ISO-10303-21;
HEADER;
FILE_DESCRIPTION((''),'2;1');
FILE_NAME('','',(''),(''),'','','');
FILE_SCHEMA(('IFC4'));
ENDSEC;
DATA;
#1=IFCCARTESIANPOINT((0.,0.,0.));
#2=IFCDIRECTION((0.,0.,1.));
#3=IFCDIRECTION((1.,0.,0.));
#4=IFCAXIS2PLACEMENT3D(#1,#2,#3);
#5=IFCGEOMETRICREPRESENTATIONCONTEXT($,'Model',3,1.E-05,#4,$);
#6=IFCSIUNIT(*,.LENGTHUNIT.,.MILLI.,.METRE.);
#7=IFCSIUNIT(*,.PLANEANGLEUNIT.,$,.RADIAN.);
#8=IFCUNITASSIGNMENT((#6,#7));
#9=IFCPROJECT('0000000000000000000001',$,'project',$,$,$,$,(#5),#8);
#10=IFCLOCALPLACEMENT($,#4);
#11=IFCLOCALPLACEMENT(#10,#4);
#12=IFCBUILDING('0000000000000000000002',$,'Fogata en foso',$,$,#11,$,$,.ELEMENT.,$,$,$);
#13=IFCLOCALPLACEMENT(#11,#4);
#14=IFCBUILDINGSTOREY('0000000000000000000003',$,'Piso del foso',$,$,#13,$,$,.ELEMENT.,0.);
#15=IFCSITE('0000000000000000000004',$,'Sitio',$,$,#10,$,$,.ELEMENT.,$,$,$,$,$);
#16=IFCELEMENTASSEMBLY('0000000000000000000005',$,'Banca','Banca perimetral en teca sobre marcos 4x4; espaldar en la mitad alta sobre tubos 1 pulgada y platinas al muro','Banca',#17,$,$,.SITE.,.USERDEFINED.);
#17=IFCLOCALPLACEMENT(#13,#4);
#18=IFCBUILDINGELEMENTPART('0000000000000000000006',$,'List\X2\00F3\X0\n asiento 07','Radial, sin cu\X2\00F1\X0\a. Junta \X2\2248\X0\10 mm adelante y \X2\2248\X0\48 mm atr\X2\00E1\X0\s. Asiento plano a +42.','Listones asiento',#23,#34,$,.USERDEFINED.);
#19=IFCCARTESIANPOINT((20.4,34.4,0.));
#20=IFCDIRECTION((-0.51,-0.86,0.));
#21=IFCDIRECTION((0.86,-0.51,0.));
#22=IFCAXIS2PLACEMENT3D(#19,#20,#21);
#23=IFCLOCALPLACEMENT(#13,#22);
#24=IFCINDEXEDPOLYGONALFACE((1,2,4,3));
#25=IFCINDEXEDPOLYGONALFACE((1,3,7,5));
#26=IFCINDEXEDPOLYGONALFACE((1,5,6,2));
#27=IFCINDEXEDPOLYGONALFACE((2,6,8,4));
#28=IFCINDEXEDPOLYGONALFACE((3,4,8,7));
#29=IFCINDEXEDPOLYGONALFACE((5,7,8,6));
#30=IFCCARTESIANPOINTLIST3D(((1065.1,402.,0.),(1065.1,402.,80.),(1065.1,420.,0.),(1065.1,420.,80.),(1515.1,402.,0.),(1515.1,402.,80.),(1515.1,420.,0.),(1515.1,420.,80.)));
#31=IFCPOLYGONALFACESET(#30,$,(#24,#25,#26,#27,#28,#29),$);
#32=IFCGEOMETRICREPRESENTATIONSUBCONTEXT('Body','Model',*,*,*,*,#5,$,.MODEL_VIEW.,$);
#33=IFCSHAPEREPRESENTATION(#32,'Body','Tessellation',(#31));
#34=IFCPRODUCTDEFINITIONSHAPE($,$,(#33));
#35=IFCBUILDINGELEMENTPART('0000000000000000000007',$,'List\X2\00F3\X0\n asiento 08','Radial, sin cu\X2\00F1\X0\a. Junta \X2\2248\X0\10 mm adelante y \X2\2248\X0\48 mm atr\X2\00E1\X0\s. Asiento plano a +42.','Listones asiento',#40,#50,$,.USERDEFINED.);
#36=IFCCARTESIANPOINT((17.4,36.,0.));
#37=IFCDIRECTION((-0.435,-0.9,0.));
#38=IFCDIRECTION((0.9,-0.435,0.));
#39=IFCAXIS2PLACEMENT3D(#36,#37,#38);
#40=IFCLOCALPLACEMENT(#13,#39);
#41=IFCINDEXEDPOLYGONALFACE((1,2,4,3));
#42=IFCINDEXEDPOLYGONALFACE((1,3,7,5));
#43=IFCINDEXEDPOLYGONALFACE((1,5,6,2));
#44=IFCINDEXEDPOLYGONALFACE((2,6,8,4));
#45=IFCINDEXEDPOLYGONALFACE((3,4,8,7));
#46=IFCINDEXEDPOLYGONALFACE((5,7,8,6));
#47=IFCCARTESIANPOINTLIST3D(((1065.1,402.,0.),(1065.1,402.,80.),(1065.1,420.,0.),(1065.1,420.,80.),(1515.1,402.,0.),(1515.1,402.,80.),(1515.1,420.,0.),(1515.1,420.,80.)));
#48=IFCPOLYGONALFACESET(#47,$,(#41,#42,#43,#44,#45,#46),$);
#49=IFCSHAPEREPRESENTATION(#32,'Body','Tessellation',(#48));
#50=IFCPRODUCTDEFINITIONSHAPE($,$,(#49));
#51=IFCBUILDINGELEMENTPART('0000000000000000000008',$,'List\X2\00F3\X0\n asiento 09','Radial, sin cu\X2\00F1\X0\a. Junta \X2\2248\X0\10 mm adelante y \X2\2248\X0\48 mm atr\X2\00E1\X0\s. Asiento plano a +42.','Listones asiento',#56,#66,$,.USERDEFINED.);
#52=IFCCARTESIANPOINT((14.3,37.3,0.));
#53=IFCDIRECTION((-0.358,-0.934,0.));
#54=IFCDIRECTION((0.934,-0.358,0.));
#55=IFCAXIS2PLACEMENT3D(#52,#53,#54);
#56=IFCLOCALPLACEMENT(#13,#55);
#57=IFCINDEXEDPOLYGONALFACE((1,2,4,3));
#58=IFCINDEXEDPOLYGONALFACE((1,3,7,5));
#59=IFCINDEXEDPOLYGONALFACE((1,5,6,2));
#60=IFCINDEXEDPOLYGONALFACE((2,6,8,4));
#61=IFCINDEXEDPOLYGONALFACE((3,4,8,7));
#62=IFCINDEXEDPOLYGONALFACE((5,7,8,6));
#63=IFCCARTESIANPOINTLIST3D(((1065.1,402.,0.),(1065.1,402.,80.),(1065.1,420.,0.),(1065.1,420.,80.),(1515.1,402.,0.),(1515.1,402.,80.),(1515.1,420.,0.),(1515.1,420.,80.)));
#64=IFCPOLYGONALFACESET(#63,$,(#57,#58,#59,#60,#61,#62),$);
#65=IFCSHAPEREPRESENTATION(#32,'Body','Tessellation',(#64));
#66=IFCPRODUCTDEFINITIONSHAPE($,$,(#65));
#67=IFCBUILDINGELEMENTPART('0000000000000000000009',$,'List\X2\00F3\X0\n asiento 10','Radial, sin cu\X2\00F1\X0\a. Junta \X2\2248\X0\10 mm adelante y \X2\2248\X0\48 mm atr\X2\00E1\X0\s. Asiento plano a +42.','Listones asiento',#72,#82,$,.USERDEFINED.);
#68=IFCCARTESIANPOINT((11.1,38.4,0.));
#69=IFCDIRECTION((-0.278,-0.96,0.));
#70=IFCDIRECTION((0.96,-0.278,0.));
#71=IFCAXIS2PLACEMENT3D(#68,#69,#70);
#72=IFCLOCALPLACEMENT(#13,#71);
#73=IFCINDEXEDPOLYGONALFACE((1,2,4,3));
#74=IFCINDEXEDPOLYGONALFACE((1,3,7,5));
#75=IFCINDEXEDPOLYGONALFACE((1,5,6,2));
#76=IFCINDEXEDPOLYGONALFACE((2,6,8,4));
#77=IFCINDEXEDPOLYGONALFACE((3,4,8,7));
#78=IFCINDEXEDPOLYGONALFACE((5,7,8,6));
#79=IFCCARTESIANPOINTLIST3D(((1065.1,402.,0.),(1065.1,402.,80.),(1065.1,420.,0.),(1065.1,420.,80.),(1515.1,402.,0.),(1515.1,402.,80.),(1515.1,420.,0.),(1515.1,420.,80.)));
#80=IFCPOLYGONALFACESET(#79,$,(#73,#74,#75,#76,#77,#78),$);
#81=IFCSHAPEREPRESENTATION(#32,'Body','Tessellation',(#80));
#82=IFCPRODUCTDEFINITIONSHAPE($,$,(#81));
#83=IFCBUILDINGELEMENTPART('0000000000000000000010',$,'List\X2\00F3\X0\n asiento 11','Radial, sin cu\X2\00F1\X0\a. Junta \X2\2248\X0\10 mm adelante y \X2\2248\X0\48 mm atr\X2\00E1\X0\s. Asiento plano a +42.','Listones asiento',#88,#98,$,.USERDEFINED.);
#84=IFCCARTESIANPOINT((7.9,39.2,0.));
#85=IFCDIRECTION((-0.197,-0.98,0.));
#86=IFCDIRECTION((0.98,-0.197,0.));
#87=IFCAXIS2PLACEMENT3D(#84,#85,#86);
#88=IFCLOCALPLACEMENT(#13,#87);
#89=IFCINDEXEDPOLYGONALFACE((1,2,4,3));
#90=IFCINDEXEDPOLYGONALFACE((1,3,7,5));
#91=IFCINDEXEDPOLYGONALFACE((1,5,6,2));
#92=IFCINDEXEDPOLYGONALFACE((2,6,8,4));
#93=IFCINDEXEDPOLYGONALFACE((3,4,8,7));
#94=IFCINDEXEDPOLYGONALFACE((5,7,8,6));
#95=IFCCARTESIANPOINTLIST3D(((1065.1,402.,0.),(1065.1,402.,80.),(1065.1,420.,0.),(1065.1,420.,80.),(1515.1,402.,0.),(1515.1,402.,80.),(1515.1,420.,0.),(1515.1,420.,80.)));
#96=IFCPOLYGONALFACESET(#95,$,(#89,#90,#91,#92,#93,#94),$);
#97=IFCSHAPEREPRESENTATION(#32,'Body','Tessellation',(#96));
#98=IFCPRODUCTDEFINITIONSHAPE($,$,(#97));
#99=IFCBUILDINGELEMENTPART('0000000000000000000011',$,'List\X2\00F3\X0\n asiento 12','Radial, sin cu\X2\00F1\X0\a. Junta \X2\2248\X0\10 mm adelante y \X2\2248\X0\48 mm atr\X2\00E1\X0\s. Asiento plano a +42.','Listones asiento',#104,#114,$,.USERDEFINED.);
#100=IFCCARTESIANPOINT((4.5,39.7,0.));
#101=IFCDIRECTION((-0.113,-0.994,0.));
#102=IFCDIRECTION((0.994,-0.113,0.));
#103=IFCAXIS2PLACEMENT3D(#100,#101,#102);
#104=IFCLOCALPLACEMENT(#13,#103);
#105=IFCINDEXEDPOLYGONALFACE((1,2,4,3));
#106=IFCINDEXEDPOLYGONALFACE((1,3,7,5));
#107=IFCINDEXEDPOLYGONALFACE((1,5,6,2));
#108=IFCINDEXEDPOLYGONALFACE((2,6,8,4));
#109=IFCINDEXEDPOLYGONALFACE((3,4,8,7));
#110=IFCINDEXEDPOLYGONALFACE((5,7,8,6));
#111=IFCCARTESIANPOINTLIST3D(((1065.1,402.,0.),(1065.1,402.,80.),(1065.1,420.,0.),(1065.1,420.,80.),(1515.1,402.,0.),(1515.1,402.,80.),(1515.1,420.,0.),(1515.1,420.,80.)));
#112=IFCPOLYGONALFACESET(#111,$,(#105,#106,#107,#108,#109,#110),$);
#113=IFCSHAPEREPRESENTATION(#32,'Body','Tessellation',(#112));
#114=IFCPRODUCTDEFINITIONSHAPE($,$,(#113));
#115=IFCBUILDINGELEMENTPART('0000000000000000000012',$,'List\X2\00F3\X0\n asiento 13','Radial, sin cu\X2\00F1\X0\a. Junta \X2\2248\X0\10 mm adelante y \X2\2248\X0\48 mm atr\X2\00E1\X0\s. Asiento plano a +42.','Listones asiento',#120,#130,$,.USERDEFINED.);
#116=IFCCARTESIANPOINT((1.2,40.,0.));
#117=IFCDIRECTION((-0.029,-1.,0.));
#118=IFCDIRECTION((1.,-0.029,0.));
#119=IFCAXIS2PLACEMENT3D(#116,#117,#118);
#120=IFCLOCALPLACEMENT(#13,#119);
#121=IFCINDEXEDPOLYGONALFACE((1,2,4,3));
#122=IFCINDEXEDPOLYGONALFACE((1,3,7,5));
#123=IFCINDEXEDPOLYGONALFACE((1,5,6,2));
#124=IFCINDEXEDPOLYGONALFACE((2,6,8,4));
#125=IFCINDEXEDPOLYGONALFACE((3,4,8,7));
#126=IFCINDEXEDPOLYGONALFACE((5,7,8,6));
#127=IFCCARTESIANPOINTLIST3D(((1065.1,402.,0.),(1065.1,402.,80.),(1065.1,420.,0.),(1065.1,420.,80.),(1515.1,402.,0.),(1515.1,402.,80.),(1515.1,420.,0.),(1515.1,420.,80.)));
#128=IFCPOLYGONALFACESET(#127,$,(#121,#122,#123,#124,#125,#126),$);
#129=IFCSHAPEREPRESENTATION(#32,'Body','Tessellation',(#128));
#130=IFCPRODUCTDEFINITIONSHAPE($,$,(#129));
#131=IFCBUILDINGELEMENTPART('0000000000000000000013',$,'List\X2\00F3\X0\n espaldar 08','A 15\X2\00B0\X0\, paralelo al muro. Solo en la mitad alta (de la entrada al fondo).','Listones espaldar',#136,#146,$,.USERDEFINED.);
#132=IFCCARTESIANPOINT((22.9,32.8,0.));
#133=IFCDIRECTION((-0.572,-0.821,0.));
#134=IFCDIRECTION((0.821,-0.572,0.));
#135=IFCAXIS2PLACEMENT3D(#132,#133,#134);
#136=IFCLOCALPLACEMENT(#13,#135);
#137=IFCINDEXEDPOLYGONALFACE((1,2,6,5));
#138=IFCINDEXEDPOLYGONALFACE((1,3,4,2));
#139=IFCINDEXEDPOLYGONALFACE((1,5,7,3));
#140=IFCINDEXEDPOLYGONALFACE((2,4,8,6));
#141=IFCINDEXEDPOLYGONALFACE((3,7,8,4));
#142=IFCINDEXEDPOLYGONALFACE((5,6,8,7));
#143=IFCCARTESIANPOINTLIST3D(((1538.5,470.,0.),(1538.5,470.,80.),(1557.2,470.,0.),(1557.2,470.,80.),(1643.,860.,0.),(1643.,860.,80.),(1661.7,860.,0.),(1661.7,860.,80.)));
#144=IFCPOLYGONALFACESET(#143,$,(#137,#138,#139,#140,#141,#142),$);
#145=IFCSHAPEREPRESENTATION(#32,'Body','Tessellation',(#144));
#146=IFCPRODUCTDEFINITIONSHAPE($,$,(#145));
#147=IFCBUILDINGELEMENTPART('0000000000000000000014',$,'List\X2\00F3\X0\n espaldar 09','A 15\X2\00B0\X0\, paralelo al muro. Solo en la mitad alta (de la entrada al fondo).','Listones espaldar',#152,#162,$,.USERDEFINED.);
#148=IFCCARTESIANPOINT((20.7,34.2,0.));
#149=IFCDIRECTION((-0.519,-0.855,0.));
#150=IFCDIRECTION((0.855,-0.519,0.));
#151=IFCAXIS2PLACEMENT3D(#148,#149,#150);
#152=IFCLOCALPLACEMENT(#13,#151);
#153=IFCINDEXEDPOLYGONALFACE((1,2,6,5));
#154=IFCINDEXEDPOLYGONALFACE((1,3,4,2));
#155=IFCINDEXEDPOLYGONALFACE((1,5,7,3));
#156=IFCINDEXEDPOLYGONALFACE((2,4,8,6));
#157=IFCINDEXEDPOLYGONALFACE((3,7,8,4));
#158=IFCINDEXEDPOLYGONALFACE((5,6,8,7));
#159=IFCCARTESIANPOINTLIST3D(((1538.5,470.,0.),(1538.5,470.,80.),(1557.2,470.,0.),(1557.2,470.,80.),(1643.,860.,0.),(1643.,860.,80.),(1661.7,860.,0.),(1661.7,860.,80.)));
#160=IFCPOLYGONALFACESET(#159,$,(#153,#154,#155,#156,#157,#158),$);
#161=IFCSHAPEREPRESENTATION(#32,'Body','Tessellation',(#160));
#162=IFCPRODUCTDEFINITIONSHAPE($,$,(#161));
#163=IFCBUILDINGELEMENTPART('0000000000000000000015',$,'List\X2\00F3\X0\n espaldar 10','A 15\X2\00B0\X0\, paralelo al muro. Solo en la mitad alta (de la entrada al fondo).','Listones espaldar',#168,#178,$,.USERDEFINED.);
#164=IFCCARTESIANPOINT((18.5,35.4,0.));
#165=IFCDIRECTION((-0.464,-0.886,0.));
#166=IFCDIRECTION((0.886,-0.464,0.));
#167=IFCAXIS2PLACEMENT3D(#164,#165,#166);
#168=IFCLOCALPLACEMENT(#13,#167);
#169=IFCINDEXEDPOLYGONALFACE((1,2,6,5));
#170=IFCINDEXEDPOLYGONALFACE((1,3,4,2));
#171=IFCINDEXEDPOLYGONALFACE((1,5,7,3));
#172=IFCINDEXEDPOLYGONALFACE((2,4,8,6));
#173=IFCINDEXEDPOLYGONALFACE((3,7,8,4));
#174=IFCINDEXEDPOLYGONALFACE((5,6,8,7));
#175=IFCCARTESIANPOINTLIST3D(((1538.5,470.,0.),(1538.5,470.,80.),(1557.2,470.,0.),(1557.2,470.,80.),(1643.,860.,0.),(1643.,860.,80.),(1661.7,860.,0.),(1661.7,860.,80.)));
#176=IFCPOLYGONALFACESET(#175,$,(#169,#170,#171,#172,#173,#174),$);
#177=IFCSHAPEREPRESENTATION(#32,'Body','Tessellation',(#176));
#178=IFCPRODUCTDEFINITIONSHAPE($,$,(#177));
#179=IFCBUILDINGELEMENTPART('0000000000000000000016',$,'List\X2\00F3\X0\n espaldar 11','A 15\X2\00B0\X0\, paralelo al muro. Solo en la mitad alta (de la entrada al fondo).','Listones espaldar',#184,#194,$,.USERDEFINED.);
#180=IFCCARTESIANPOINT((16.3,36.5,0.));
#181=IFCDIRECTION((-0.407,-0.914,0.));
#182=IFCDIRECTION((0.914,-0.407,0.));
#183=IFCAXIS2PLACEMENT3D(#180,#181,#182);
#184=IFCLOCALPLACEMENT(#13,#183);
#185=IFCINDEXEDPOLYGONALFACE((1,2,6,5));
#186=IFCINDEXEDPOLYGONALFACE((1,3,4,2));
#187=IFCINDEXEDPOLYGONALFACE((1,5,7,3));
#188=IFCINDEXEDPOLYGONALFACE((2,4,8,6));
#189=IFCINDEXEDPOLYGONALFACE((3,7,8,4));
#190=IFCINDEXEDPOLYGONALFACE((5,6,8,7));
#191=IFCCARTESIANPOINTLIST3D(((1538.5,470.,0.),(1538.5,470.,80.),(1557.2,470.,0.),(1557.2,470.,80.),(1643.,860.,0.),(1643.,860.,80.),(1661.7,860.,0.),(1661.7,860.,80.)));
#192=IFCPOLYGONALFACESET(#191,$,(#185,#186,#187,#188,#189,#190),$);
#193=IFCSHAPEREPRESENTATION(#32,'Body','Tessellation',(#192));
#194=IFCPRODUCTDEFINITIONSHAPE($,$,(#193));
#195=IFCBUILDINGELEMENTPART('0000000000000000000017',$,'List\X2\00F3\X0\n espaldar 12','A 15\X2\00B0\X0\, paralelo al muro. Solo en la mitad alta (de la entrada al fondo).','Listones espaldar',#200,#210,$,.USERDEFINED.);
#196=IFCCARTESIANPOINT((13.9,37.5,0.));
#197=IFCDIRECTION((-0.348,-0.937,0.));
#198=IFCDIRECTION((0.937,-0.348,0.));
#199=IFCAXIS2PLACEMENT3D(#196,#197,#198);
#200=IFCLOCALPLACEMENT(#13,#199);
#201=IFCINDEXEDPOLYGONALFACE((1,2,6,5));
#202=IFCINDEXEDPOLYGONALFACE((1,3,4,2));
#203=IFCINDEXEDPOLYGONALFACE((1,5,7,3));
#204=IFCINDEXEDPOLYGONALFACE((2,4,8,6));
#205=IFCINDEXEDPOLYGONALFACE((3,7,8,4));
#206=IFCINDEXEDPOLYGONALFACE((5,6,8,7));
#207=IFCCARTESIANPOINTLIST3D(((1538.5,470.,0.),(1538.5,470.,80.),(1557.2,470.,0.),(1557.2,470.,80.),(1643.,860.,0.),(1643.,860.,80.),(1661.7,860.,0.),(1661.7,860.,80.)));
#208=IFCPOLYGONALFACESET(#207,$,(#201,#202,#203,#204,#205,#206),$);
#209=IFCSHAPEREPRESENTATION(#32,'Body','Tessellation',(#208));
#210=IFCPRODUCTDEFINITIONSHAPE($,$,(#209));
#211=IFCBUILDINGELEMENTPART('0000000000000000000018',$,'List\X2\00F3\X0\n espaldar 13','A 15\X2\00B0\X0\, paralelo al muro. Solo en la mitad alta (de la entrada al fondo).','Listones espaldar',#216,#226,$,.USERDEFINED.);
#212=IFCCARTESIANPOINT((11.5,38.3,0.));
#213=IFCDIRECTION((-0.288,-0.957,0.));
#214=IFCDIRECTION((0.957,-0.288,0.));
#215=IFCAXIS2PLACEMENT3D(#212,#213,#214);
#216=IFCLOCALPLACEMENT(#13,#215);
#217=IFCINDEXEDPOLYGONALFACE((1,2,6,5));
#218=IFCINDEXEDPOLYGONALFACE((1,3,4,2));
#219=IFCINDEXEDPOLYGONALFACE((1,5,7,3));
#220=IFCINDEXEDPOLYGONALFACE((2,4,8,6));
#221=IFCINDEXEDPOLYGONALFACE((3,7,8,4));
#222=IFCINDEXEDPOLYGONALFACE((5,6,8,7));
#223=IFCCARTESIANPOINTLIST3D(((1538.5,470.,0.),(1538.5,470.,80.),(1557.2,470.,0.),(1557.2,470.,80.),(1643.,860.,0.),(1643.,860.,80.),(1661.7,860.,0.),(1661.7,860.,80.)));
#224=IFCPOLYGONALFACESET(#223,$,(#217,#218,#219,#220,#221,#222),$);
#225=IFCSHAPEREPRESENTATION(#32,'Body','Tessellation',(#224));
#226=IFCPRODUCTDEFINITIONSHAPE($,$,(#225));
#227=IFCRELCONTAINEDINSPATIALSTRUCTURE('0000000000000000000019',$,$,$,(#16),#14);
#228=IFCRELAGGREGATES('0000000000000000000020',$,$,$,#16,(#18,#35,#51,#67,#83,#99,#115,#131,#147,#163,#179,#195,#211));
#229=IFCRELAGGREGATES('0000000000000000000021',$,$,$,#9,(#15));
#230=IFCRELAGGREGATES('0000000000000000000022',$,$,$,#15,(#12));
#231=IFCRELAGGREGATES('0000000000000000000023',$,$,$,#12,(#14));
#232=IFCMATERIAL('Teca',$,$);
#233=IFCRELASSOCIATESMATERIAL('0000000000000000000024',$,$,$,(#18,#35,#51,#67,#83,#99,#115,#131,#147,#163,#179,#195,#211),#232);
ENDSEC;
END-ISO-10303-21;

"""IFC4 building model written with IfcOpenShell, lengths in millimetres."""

from ifc_helpers import new_model, si_unit, frame, origin_with_axes, place, context, subcontext, project, spatial, polyline, outline, extrude, material, element, aggregate, save


model = new_model("IFC4")

# Units and contexts
model_context = context("Model", 3, precision=1e-05, world=origin_with_axes())
body_context = subcontext(model_context, "Body", "Model", "MODEL_VIEW")
ifc_project = project(units=[si_unit("LENGTHUNIT", "METRE", prefix="MILLI"), si_unit("PLANEANGLEUNIT", "RADIAN")], contexts=[model_context])

# Site, building, storey
site_placement = place(None, origin_with_axes())
site = spatial("IfcSite", under=ifc_project, at=site_placement, Name="Sitio", CompositionType="ELEMENT")
building_placement = place(site_placement, origin_with_axes())
building = spatial("IfcBuilding", under=site, at=building_placement, Name="Fogata en foso", CompositionType="ELEMENT")
storey_placement = place(building_placement, origin_with_axes())
storey = spatial("IfcBuildingStorey", under=building, at=storey_placement, Name="Piso del foso", CompositionType="ELEMENT", Elevation=0.0)

# Element assembly, building element parts
assembly_1_placement = place(storey_placement, origin_with_axes())
assembly_1 = element("IfcElementAssembly", 1, at=assembly_1_placement, inside=storey, Name="Banca", Description="Banca perimetral en teca sobre marcos 4x4; espaldar en la mitad alta sobre tubos 1 pulgada y platinas al muro", ObjectType="Banca", AssemblyPlace="SITE", PredefinedType="USERDEFINED")
ifc_material = material(Name="Teca")
building_element_part_1_placement = place(storey_placement, frame((20.4, 34.4, 0.0), z_axis=(-0.51, -0.86, 0.0), x_axis=(0.86, -0.51, 0.0)))
building_element_part_1 = element("IfcBuildingElementPart", 2, at=building_element_part_1_placement, material=ifc_material, Name="Listón asiento 07", Description="Radial, sin cuña. Junta ≈10 mm adelante y ≈48 mm atrás. Asiento plano a +42.", ObjectType="Listones asiento", PredefinedType="USERDEFINED", context=body_context, shape_type="SweptSolid", body=[
    extrude(outline(polyline([(1065.1, 402.0), (1515.1, 402.0), (1515.1, 420.0), (1065.1, 420.0), (1065.1, 402.0)])), origin_with_axes(), (0.0, 0.0, 1.0), 80.0),
])
building_element_part_2_placement = place(storey_placement, frame((17.4, 36.0, 0.0), z_axis=(-0.435, -0.9, 0.0), x_axis=(0.9, -0.435, 0.0)))
building_element_part_2 = element("IfcBuildingElementPart", 3, at=building_element_part_2_placement, material=ifc_material, Name="Listón asiento 08", Description="Radial, sin cuña. Junta ≈10 mm adelante y ≈48 mm atrás. Asiento plano a +42.", ObjectType="Listones asiento", PredefinedType="USERDEFINED", context=body_context, shape_type="SweptSolid", body=[
    extrude(outline(polyline([(1065.1, 402.0), (1515.1, 402.0), (1515.1, 420.0), (1065.1, 420.0), (1065.1, 402.0)])), origin_with_axes(), (0.0, 0.0, 1.0), 80.0),
])
building_element_part_3_placement = place(storey_placement, frame((14.3, 37.3, 0.0), z_axis=(-0.358, -0.934, 0.0), x_axis=(0.934, -0.358, 0.0)))
building_element_part_3 = element("IfcBuildingElementPart", 4, at=building_element_part_3_placement, material=ifc_material, Name="Listón asiento 09", Description="Radial, sin cuña. Junta ≈10 mm adelante y ≈48 mm atrás. Asiento plano a +42.", ObjectType="Listones asiento", PredefinedType="USERDEFINED", context=body_context, shape_type="SweptSolid", body=[
    extrude(outline(polyline([(1065.1, 402.0), (1515.1, 402.0), (1515.1, 420.0), (1065.1, 420.0), (1065.1, 402.0)])), origin_with_axes(), (0.0, 0.0, 1.0), 80.0),
])
building_element_part_4_placement = place(storey_placement, frame((11.1, 38.4, 0.0), z_axis=(-0.278, -0.96, 0.0), x_axis=(0.96, -0.278, 0.0)))
building_element_part_4 = element("IfcBuildingElementPart", 5, at=building_element_part_4_placement, material=ifc_material, Name="Listón asiento 10", Description="Radial, sin cuña. Junta ≈10 mm adelante y ≈48 mm atrás. Asiento plano a +42.", ObjectType="Listones asiento", PredefinedType="USERDEFINED", context=body_context, shape_type="SweptSolid", body=[
    extrude(outline(polyline([(1065.1, 402.0), (1515.1, 402.0), (1515.1, 420.0), (1065.1, 420.0), (1065.1, 402.0)])), origin_with_axes(), (0.0, 0.0, 1.0), 80.0),
])
building_element_part_5_placement = place(storey_placement, frame((7.9, 39.2, 0.0), z_axis=(-0.197, -0.98, 0.0), x_axis=(0.98, -0.197, 0.0)))
building_element_part_5 = element("IfcBuildingElementPart", 6, at=building_element_part_5_placement, material=ifc_material, Name="Listón asiento 11", Description="Radial, sin cuña. Junta ≈10 mm adelante y ≈48 mm atrás. Asiento plano a +42.", ObjectType="Listones asiento", PredefinedType="USERDEFINED", context=body_context, shape_type="SweptSolid", body=[
    extrude(outline(polyline([(1065.1, 402.0), (1515.1, 402.0), (1515.1, 420.0), (1065.1, 420.0), (1065.1, 402.0)])), origin_with_axes(), (0.0, 0.0, 1.0), 80.0),
])
building_element_part_6_placement = place(storey_placement, frame((4.5, 39.7, 0.0), z_axis=(-0.113, -0.994, 0.0), x_axis=(0.994, -0.113, 0.0)))
building_element_part_6 = element("IfcBuildingElementPart", 7, at=building_element_part_6_placement, material=ifc_material, Name="Listón asiento 12", Description="Radial, sin cuña. Junta ≈10 mm adelante y ≈48 mm atrás. Asiento plano a +42.", ObjectType="Listones asiento", PredefinedType="USERDEFINED", context=body_context, shape_type="SweptSolid", body=[
    extrude(outline(polyline([(1065.1, 402.0), (1515.1, 402.0), (1515.1, 420.0), (1065.1, 420.0), (1065.1, 402.0)])), origin_with_axes(), (0.0, 0.0, 1.0), 80.0),
])
building_element_part_7_placement = place(storey_placement, frame((1.2, 40.0, 0.0), z_axis=(-0.029, -1.0, 0.0), x_axis=(1.0, -0.029, 0.0)))
building_element_part_7 = element("IfcBuildingElementPart", 8, at=building_element_part_7_placement, material=ifc_material, Name="Listón asiento 13", Description="Radial, sin cuña. Junta ≈10 mm adelante y ≈48 mm atrás. Asiento plano a +42.", ObjectType="Listones asiento", PredefinedType="USERDEFINED", context=body_context, shape_type="SweptSolid", body=[
    extrude(outline(polyline([(1065.1, 402.0), (1515.1, 402.0), (1515.1, 420.0), (1065.1, 420.0), (1065.1, 402.0)])), origin_with_axes(), (0.0, 0.0, 1.0), 80.0),
])
building_element_part_8_placement = place(storey_placement, frame((22.9, 32.8, 0.0), z_axis=(-0.572, -0.821, 0.0), x_axis=(0.821, -0.572, 0.0)))
building_element_part_8 = element("IfcBuildingElementPart", 9, at=building_element_part_8_placement, material=ifc_material, Name="Listón espaldar 08", Description="A 15°, paralelo al muro. Solo en la mitad alta (de la entrada al fondo).", ObjectType="Listones espaldar", PredefinedType="USERDEFINED", context=body_context, shape_type="SweptSolid", body=[
    extrude(outline(polyline([(1538.5, 470.0), (1557.2, 470.0), (1661.7, 860.0), (1643.0, 860.0), (1538.5, 470.0)])), origin_with_axes(), (0.0, 0.0, 1.0), 80.0),
])
building_element_part_9_placement = place(storey_placement, frame((20.7, 34.2, 0.0), z_axis=(-0.519, -0.855, 0.0), x_axis=(0.855, -0.519, 0.0)))
building_element_part_9 = element("IfcBuildingElementPart", 10, at=building_element_part_9_placement, material=ifc_material, Name="Listón espaldar 09", Description="A 15°, paralelo al muro. Solo en la mitad alta (de la entrada al fondo).", ObjectType="Listones espaldar", PredefinedType="USERDEFINED", context=body_context, shape_type="SweptSolid", body=[
    extrude(outline(polyline([(1538.5, 470.0), (1557.2, 470.0), (1661.7, 860.0), (1643.0, 860.0), (1538.5, 470.0)])), origin_with_axes(), (0.0, 0.0, 1.0), 80.0),
])
building_element_part_10_placement = place(storey_placement, frame((18.5, 35.4, 0.0), z_axis=(-0.464, -0.886, 0.0), x_axis=(0.886, -0.464, 0.0)))
building_element_part_10 = element("IfcBuildingElementPart", 11, at=building_element_part_10_placement, material=ifc_material, Name="Listón espaldar 10", Description="A 15°, paralelo al muro. Solo en la mitad alta (de la entrada al fondo).", ObjectType="Listones espaldar", PredefinedType="USERDEFINED", context=body_context, shape_type="SweptSolid", body=[
    extrude(outline(polyline([(1538.5, 470.0), (1557.2, 470.0), (1661.7, 860.0), (1643.0, 860.0), (1538.5, 470.0)])), origin_with_axes(), (0.0, 0.0, 1.0), 80.0),
])
building_element_part_11_placement = place(storey_placement, frame((16.3, 36.5, 0.0), z_axis=(-0.407, -0.914, 0.0), x_axis=(0.914, -0.407, 0.0)))
building_element_part_11 = element("IfcBuildingElementPart", 12, at=building_element_part_11_placement, material=ifc_material, Name="Listón espaldar 11", Description="A 15°, paralelo al muro. Solo en la mitad alta (de la entrada al fondo).", ObjectType="Listones espaldar", PredefinedType="USERDEFINED", context=body_context, shape_type="SweptSolid", body=[
    extrude(outline(polyline([(1538.5, 470.0), (1557.2, 470.0), (1661.7, 860.0), (1643.0, 860.0), (1538.5, 470.0)])), origin_with_axes(), (0.0, 0.0, 1.0), 80.0),
])
building_element_part_12_placement = place(storey_placement, frame((13.9, 37.5, 0.0), z_axis=(-0.348, -0.937, 0.0), x_axis=(0.937, -0.348, 0.0)))
building_element_part_12 = element("IfcBuildingElementPart", 13, at=building_element_part_12_placement, material=ifc_material, Name="Listón espaldar 12", Description="A 15°, paralelo al muro. Solo en la mitad alta (de la entrada al fondo).", ObjectType="Listones espaldar", PredefinedType="USERDEFINED", context=body_context, shape_type="SweptSolid", body=[
    extrude(outline(polyline([(1538.5, 470.0), (1557.2, 470.0), (1661.7, 860.0), (1643.0, 860.0), (1538.5, 470.0)])), origin_with_axes(), (0.0, 0.0, 1.0), 80.0),
])
building_element_part_13_placement = place(storey_placement, frame((11.5, 38.3, 0.0), z_axis=(-0.288, -0.957, 0.0), x_axis=(0.957, -0.288, 0.0)))
building_element_part_13 = element("IfcBuildingElementPart", 14, at=building_element_part_13_placement, material=ifc_material, Name="Listón espaldar 13", Description="A 15°, paralelo al muro. Solo en la mitad alta (de la entrada al fondo).", ObjectType="Listones espaldar", PredefinedType="USERDEFINED", context=body_context, shape_type="SweptSolid", body=[
    extrude(outline(polyline([(1538.5, 470.0), (1557.2, 470.0), (1661.7, 860.0), (1643.0, 860.0), (1538.5, 470.0)])), origin_with_axes(), (0.0, 0.0, 1.0), 80.0),
])
aggregate(assembly_1, [building_element_part_1, building_element_part_2, building_element_part_3, building_element_part_4, building_element_part_5, building_element_part_6, building_element_part_7, building_element_part_8, building_element_part_9, building_element_part_10, building_element_part_11, building_element_part_12, building_element_part_13])

save(model, "model.ifc")
